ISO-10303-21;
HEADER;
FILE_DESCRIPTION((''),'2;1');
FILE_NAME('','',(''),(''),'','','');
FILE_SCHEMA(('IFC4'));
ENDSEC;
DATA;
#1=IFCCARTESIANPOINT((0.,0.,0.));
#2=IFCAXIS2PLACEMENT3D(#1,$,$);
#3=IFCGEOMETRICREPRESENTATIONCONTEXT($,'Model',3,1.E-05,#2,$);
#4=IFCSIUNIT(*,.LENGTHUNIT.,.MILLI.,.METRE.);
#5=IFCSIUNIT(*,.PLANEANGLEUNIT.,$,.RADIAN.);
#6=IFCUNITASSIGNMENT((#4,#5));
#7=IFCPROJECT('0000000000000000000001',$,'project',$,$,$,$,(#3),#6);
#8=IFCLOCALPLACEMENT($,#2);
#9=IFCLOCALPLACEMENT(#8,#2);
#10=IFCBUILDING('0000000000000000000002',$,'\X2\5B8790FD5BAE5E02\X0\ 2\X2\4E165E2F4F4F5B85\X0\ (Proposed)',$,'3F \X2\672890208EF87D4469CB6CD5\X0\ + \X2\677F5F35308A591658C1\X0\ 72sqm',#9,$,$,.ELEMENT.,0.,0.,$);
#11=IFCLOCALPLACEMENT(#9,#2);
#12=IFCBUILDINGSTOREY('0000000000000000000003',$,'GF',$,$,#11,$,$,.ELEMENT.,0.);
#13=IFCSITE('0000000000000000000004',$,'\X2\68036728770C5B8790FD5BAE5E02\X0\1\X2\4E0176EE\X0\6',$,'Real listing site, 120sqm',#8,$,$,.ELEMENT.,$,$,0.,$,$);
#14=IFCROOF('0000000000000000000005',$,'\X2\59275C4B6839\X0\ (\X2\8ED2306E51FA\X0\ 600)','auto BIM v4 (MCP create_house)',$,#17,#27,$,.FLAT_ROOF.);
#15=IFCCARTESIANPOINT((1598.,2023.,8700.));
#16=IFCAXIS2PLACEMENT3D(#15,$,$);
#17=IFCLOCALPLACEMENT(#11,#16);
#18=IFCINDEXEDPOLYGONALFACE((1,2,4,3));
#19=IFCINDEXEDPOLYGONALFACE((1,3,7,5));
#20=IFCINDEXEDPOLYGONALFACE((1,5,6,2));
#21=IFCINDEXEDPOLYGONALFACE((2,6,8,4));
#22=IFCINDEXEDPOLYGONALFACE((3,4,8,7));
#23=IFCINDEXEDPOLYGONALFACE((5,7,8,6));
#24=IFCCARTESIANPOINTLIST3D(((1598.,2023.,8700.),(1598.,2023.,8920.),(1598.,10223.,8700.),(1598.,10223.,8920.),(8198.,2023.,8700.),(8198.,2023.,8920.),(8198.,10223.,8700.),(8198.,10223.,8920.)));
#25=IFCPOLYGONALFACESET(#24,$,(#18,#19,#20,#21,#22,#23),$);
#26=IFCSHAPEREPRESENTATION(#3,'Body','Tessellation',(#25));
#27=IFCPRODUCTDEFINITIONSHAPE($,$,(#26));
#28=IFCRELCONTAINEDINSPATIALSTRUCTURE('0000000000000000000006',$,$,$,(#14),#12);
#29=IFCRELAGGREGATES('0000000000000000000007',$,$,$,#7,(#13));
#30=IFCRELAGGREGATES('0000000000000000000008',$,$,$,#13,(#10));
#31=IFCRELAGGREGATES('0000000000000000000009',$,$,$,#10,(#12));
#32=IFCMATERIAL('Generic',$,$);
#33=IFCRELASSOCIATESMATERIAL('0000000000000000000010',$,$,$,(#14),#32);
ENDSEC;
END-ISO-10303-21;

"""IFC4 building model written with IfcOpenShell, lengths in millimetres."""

from ifc_helpers import new_model, si_unit, frame, frame_2d, origin, place, context, project, spatial, rectangle, extrude, material, element, save


model = new_model("IFC4")

# Units and contexts
model_context = context("Model", 3, precision=1e-05, world=origin())
ifc_project = project(units=[si_unit("LENGTHUNIT", "METRE", prefix="MILLI"), si_unit("PLANEANGLEUNIT", "RADIAN")], contexts=[model_context])

# Site, building, storey
site_placement = place(None, origin())
site = spatial("IfcSite", under=ifc_project, at=site_placement, Name="栃木県宇都宮市1丁目6", ObjectType="Real listing site, 120sqm", CompositionType="ELEMENT", RefElevation=0.0)
building_placement = place(site_placement, origin())
building = spatial("IfcBuilding", under=site, at=building_placement, Name="宇都宮市 2世帯住宅 (Proposed)", ObjectType="3F 木造軸組構法 + 板張り外壁 72sqm", CompositionType="ELEMENT", ElevationOfRefHeight=0.0, ElevationOfTerrain=0.0)
storey_placement = place(building_placement, origin())
storey = spatial("IfcBuildingStorey", under=building, at=storey_placement, Name="GF", CompositionType="ELEMENT", Elevation=0.0)

# Shared definitions
ifc_material = material(Name="Generic")

# Roof
roof_placement = place(storey_placement, frame((1598.0, 2023.0, 8700.0)))
element("IfcRoof", 1, at=roof_placement, inside=storey, material=ifc_material, Name="大屋根 (軒の出 600)", Description="auto BIM v4 (MCP create_house)", PredefinedType="FLAT_ROOF", context=model_context, shape_type="SweptSolid", body=[
    extrude(rectangle(XDim=6600.0, YDim=8200.0, at=frame_2d((3300.0, 4100.0))), frame((1598.0, 2023.0, 8700.0)), (0.0, 0.0, 1.0), 220.0),
])

save(model, "model.ifc")
